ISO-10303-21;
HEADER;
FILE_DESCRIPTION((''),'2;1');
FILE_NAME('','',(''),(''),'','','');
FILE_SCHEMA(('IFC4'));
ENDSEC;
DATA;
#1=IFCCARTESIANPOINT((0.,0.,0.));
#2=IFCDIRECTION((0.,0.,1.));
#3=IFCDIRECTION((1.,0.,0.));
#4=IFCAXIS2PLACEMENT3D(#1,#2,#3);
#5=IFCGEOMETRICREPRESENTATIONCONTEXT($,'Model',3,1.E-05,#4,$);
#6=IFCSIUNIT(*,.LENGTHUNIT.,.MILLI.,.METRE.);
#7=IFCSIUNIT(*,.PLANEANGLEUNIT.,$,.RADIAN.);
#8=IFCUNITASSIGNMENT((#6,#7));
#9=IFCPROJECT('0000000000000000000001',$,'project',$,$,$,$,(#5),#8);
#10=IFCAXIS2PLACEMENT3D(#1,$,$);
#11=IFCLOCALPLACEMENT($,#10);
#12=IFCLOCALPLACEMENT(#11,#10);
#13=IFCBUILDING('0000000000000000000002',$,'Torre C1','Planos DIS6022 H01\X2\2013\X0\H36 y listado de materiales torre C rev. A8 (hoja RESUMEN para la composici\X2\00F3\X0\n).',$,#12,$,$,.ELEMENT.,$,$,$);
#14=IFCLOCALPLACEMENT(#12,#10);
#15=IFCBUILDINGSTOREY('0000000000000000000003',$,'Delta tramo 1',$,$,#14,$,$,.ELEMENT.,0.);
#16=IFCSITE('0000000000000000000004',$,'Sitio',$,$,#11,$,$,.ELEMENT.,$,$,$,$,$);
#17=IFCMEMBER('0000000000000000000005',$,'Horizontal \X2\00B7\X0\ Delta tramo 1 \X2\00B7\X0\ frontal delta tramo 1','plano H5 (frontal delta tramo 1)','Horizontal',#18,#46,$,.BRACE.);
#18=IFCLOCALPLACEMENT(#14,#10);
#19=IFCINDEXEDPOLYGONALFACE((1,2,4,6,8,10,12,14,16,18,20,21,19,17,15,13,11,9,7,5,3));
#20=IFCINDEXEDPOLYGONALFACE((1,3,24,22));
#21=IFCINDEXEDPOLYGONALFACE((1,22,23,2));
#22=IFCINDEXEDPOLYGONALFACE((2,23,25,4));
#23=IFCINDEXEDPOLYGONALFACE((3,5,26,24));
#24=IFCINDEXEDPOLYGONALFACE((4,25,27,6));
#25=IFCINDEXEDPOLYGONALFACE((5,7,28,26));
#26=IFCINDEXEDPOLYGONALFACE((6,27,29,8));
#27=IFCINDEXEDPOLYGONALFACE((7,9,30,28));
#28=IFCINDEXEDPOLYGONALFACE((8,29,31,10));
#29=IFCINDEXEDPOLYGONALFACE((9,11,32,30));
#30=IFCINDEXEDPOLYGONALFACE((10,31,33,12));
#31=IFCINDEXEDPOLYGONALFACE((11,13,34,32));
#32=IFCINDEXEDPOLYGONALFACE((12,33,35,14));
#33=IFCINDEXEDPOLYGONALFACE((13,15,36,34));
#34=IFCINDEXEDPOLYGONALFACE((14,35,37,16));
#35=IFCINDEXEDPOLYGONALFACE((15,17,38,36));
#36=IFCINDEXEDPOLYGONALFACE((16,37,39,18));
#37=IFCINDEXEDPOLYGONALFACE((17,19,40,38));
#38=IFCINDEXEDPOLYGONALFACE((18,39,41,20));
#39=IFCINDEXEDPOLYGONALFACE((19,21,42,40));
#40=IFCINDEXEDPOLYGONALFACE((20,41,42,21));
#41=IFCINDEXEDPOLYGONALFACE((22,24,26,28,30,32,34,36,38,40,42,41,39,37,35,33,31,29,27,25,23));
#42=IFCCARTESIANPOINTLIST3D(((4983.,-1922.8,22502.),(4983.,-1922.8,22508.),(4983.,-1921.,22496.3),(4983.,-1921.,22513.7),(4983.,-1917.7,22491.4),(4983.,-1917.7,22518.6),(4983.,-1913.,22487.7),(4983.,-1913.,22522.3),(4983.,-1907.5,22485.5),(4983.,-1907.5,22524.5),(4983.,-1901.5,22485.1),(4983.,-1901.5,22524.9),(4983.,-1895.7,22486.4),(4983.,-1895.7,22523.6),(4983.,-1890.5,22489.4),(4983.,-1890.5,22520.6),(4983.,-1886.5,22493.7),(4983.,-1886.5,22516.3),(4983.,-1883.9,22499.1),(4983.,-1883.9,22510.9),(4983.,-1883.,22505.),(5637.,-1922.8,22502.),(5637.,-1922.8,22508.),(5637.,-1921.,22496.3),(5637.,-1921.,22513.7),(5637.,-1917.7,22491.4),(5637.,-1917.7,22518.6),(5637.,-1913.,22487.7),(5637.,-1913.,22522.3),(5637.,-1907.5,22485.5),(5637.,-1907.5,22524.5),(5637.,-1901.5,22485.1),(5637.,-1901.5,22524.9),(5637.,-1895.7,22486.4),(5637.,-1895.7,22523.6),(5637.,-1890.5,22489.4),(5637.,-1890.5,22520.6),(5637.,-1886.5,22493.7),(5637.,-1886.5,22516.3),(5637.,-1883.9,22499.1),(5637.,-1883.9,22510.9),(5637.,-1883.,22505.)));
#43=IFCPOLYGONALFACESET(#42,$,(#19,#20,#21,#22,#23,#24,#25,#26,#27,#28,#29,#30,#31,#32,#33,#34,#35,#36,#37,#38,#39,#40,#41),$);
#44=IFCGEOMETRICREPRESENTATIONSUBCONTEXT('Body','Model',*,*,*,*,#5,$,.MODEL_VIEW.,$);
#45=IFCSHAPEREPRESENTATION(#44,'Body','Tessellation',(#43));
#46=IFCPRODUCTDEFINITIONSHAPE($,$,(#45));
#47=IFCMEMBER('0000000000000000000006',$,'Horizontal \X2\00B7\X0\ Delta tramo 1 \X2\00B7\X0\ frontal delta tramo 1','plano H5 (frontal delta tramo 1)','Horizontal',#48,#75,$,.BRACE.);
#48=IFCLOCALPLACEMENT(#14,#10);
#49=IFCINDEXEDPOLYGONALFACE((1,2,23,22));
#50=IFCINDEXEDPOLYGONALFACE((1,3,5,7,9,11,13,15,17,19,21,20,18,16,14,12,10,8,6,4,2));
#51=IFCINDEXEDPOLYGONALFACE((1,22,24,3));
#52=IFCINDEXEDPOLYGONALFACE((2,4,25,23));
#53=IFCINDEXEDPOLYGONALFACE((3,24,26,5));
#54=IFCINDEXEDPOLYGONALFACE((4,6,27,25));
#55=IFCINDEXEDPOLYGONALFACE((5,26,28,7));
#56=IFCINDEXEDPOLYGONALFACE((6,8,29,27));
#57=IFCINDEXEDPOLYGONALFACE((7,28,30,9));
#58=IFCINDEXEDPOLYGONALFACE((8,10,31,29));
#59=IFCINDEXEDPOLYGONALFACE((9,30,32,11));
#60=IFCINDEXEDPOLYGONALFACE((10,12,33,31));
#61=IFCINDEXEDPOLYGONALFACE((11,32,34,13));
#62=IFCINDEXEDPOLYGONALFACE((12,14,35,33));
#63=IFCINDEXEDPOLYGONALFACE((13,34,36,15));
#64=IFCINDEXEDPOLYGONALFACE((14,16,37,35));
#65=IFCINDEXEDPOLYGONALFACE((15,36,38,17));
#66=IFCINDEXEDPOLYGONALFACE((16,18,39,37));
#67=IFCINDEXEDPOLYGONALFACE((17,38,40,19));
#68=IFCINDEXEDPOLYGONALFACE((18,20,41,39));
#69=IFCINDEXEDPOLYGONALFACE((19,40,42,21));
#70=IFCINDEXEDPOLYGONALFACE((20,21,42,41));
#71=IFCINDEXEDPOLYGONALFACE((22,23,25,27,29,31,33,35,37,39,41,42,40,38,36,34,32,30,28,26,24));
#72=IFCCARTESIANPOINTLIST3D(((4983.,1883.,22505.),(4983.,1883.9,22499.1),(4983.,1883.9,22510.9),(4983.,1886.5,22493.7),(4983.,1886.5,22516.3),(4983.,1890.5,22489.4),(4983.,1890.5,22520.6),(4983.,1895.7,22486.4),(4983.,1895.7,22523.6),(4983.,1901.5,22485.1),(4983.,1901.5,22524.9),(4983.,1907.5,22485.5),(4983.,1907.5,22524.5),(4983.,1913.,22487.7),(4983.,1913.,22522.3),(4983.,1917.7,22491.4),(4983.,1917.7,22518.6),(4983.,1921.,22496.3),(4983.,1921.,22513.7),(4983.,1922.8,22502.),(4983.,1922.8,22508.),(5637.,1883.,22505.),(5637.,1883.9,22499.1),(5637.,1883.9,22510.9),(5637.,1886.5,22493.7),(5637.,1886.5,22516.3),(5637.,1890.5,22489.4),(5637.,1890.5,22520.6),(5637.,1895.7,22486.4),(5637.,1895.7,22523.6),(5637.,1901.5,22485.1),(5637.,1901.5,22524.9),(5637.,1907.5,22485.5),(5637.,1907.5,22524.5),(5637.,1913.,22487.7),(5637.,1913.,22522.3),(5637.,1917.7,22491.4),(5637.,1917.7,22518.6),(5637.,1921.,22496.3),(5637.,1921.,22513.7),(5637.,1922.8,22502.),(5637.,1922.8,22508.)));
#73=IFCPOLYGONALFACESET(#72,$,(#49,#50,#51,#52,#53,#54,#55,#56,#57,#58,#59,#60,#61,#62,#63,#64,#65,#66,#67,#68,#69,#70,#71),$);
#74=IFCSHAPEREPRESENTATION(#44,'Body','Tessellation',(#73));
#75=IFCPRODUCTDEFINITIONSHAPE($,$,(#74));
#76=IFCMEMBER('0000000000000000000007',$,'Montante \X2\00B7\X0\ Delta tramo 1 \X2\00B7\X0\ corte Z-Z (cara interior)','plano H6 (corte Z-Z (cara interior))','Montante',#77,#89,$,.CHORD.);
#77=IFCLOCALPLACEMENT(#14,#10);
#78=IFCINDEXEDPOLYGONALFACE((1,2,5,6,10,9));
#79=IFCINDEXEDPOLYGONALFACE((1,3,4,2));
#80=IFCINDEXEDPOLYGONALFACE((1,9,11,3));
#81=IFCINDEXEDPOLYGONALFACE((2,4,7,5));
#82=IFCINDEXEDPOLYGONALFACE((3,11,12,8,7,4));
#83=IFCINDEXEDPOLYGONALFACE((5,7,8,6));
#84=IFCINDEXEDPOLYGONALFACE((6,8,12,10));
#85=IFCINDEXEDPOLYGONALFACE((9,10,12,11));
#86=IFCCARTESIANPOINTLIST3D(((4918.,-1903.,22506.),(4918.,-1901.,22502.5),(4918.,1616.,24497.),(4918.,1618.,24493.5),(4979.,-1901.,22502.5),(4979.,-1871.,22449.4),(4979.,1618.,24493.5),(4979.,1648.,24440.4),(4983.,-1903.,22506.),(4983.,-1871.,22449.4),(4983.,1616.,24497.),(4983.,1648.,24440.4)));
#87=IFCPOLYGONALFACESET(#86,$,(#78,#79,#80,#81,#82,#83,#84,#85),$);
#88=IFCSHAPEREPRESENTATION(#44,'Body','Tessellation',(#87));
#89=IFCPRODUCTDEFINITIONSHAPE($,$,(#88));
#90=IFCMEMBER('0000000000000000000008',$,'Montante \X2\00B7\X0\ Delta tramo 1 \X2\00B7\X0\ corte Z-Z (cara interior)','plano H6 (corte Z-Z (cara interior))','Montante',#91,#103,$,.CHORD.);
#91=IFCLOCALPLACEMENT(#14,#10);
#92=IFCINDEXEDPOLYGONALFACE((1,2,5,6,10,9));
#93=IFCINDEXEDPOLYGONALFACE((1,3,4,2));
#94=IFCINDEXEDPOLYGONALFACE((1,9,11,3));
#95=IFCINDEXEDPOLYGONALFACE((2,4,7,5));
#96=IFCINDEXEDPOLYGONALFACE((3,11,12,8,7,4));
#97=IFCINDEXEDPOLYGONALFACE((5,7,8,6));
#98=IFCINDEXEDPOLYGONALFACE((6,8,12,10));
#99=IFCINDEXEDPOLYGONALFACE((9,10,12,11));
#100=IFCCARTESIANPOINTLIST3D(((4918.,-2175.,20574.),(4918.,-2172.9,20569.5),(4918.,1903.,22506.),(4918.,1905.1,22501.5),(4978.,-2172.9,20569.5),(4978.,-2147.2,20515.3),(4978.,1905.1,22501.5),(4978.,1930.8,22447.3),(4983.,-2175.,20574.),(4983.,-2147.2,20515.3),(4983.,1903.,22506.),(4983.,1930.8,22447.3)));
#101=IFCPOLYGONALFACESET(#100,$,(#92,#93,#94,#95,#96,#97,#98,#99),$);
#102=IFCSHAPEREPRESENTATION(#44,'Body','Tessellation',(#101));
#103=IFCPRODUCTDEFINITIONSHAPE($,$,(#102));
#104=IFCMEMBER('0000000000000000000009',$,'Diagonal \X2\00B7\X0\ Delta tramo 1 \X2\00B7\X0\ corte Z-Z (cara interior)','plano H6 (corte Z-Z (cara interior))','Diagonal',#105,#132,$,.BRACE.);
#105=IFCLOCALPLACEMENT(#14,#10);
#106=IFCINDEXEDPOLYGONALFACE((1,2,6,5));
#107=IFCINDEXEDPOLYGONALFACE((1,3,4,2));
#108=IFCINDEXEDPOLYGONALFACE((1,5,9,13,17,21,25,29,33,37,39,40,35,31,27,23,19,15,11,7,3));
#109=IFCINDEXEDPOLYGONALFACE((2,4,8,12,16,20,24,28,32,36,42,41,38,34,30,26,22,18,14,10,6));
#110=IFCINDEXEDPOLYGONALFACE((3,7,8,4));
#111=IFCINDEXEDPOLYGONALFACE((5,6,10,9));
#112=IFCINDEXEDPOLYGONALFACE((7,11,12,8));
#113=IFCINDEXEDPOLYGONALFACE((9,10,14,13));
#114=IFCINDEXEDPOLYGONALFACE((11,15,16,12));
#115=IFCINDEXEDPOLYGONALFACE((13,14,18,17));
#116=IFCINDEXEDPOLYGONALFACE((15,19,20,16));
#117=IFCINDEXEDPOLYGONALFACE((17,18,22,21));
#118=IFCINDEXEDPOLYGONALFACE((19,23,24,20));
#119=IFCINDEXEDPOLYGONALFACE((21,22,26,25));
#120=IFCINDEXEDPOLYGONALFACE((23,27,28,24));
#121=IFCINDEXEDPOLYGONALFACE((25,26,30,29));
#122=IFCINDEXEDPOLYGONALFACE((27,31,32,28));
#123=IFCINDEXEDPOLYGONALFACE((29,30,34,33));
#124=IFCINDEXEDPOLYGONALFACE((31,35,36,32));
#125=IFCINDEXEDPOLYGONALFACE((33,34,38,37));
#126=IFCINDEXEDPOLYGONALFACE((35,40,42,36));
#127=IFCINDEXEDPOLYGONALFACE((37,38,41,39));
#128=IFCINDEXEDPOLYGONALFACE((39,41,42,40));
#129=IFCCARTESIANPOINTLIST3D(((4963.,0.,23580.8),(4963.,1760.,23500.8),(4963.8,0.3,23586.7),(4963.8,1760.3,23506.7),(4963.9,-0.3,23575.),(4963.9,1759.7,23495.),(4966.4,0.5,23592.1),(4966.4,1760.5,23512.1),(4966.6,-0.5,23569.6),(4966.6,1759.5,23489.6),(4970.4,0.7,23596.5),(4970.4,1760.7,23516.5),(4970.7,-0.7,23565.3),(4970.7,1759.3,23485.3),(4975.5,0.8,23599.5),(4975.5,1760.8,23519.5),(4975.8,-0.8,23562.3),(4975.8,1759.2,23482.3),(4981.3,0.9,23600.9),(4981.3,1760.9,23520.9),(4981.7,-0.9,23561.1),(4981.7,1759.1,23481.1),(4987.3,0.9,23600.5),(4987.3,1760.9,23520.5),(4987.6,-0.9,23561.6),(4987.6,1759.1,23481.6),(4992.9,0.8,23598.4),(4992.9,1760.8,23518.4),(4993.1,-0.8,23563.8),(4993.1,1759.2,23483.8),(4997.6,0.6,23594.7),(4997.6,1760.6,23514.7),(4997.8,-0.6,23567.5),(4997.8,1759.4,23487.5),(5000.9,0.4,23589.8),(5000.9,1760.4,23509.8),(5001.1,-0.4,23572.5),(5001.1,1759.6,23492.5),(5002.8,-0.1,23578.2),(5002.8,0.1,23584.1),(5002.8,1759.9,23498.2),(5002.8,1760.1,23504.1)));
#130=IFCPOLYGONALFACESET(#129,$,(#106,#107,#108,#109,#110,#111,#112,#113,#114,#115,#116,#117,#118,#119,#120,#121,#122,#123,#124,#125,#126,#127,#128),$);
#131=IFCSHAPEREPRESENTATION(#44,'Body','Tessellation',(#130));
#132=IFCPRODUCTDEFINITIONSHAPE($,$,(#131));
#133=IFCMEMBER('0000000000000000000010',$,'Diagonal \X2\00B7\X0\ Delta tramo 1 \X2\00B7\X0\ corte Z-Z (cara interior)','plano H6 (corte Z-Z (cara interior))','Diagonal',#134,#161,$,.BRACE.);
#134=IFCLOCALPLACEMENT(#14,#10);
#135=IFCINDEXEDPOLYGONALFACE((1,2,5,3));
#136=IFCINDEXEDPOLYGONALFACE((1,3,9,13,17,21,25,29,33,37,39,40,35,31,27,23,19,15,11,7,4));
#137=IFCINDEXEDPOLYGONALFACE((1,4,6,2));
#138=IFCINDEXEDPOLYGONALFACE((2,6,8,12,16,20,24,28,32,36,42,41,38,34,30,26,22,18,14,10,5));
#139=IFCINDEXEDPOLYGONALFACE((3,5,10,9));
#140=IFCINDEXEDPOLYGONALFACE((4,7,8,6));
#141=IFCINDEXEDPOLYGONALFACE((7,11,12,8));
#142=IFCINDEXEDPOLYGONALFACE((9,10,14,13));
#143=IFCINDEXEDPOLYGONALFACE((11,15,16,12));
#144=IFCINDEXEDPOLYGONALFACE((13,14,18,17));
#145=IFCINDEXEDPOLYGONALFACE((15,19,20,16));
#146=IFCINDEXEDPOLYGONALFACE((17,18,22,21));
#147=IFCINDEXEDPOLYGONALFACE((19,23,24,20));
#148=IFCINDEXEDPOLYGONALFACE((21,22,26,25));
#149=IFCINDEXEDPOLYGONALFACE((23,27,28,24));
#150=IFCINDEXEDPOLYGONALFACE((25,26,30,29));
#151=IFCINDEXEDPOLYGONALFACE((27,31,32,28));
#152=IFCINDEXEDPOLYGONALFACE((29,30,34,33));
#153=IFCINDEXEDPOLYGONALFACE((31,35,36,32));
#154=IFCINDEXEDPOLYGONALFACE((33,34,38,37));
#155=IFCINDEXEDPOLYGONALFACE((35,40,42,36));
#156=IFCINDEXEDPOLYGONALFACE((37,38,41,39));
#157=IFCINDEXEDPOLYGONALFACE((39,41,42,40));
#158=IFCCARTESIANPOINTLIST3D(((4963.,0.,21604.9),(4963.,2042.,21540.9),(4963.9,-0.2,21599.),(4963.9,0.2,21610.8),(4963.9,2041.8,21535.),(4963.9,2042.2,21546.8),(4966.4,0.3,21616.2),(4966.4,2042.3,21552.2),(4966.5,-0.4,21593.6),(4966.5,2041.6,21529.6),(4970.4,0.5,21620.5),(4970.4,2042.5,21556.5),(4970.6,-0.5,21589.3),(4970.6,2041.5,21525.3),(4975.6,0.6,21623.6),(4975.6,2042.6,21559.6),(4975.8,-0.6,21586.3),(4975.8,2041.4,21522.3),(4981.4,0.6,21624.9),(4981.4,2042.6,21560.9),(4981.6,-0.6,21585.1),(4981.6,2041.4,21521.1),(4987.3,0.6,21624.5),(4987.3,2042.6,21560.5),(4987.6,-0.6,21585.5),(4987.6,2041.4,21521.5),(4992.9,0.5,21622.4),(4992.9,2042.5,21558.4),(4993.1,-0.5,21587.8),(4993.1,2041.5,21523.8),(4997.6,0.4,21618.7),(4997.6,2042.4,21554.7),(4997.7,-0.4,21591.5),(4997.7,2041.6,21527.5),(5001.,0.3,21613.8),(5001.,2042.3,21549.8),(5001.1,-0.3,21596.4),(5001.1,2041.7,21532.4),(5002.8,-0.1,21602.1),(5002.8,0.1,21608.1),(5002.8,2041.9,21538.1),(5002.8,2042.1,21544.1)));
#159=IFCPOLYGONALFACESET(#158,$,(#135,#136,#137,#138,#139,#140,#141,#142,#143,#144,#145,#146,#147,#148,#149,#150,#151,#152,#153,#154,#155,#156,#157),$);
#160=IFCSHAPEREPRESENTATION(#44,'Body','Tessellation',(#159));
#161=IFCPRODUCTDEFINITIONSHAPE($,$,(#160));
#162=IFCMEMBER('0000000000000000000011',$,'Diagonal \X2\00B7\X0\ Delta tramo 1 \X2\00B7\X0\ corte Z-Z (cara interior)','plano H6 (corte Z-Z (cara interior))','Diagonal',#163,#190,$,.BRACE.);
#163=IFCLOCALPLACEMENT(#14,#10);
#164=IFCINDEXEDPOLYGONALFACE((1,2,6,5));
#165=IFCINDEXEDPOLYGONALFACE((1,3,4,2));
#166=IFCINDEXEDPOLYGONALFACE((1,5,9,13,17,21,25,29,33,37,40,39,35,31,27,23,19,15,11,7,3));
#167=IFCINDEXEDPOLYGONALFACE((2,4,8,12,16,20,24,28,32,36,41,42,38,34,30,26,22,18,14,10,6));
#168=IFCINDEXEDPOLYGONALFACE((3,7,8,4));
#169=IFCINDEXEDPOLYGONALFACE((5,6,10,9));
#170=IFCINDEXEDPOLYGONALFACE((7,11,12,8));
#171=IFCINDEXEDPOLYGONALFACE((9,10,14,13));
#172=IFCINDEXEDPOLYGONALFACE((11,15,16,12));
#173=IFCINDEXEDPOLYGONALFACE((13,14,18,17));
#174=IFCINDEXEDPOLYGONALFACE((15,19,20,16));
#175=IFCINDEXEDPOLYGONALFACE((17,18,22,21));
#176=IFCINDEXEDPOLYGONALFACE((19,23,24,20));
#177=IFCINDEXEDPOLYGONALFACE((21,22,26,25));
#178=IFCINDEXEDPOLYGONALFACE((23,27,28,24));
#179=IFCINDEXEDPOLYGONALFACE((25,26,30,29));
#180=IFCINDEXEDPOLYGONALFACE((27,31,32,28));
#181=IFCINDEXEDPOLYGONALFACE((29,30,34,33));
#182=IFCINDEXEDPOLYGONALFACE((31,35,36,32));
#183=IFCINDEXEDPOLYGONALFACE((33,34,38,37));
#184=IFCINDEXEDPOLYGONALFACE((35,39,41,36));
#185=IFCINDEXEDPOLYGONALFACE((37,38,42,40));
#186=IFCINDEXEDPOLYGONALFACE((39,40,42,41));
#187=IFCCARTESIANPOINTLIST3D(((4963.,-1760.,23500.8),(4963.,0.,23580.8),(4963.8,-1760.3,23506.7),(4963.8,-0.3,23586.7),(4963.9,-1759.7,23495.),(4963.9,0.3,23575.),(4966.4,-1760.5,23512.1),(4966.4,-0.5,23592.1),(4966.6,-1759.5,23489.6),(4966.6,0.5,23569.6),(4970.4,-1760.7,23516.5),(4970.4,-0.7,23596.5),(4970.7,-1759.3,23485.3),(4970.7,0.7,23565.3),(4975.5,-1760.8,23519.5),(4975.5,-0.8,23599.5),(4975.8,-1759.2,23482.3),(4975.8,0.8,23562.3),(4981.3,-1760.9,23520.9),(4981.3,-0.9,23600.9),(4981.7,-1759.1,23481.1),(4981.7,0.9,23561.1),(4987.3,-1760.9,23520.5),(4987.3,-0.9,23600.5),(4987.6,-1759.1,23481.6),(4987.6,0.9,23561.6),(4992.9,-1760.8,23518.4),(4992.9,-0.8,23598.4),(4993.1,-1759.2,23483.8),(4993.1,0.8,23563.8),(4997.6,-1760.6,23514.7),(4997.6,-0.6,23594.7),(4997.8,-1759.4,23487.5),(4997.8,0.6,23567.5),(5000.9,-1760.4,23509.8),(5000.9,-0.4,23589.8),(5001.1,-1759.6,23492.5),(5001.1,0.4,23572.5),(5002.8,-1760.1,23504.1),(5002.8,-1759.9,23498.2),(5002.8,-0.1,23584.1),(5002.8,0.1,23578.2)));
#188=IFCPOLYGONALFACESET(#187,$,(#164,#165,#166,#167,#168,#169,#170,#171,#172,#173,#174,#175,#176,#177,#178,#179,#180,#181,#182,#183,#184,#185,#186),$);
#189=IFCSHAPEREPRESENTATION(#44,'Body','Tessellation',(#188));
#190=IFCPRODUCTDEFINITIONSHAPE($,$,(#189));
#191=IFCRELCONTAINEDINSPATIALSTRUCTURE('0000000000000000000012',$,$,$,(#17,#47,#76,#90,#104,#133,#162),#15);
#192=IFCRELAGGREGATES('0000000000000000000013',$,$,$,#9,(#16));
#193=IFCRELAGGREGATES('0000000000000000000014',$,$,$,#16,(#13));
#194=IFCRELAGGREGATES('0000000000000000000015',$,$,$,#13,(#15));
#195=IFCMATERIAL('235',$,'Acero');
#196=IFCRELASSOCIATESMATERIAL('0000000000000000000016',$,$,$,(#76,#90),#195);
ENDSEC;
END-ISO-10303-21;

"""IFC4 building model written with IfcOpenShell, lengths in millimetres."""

from ifc_helpers import new_model, si_unit, frame, frame_2d, origin, origin_with_axes, place, context, subcontext, project, spatial, circle, l_section, extrude, material, element, save


model = new_model("IFC4")

# Units and contexts
model_context = context("Model", 3, precision=1e-05, world=origin_with_axes())
body_context = subcontext(model_context, "Body", "Model", "MODEL_VIEW")
ifc_project = project(units=[si_unit("LENGTHUNIT", "METRE", prefix="MILLI"), si_unit("PLANEANGLEUNIT", "RADIAN")], contexts=[model_context])

# Site, building, storey
site_placement = place(None, origin())
site = spatial("IfcSite", under=ifc_project, at=site_placement, Name="Sitio", CompositionType="ELEMENT")
building_placement = place(site_placement, origin())
building = spatial("IfcBuilding", under=site, at=building_placement, Name="Torre C1", Description="Planos DIS6022 H01–H36 y listado de materiales torre C rev. A8 (hoja RESUMEN para la composición).", CompositionType="ELEMENT")
storey_placement = place(building_placement, origin())
storey = spatial("IfcBuildingStorey", under=building, at=storey_placement, Name="Delta tramo 1", CompositionType="ELEMENT", Elevation=0.0)

# Members
for number, where, z_axis, x_axis, name in (
    (1, (5637.0, -1903.0, 22505.0), (-1.0, 0.0, 0.0), (0.0, 1.0, 0.0), "Horizontal · Delta tramo 1 · frontal delta tramo 1"),
    (2, (5637.0, 1903.0, 22505.0), (-1.0, 0.0, 0.0), (0.0, -1.0, 0.0), "Horizontal · Delta tramo 1 · frontal delta tramo 1"),
):
    element("IfcMember", number, at=place(storey_placement, frame(where, z_axis=z_axis, x_axis=x_axis)), inside=storey, Name=name, Description="plano H5 (frontal delta tramo 1)", ObjectType="Horizontal", PredefinedType="BRACE", context=body_context, shape_type="SweptSolid", body=[
        extrude(circle(Radius=20.0), None, (0.0, 0.0, 1.0), 654.0),
    ])
ifc_material_1 = material(Name="235", Category="Acero")
member_1_placement = place(storey_placement, frame((4983.0, -1903.0, 22506.0), z_axis=(0.0, 0.870351, 0.492432), x_axis=(0.0, 0.492432, -0.870351)))
element("IfcMember", 3, at=member_1_placement, inside=storey, material=ifc_material_1, Name="Montante · Delta tramo 1 · corte Z-Z (cara interior)", Description="plano H6 (corte Z-Z (cara interior))", ObjectType="Montante", PredefinedType="CHORD", context=body_context, shape_type="SweptSolid", body=[
    extrude(l_section(Depth=65.0, Width=65.0, Thickness=4.0, at=frame_2d((32.5, 32.5))), None, (0.0, 0.0, 1.0), 4043.2),
])
member_2_placement = place(storey_placement, frame((4983.0, 1903.0, 22506.0), z_axis=(0.0, -0.903711, -0.428144), x_axis=(-1.0, 0.0, 0.0)))
element("IfcMember", 4, at=member_2_placement, inside=storey, material=ifc_material_1, Name="Montante · Delta tramo 1 · corte Z-Z (cara interior)", Description="plano H6 (corte Z-Z (cara interior))", ObjectType="Montante", PredefinedType="CHORD", context=body_context, shape_type="SweptSolid", body=[
    extrude(l_section(Depth=65.0, Width=65.0, Thickness=5.0, at=frame_2d((32.5, 32.5))), None, (0.0, 0.0, 1.0), 4512.5),
])
member_3_placement = place(storey_placement, frame((4983.0, 1760.0, 23501.0), z_axis=(0.0, -0.998969, 0.045408), x_axis=(-0.999968, -0.000364, -0.00801)))
element("IfcMember", 5, at=member_3_placement, inside=storey, Name="Diagonal · Delta tramo 1 · corte Z-Z (cara interior)", Description="plano H6 (corte Z-Z (cara interior))", ObjectType="Diagonal", PredefinedType="BRACE", context=body_context, shape_type="SweptSolid", body=[
    extrude(circle(Radius=20.0), None, (0.0, 0.0, 1.0), 1761.8),
])
member_4_placement = place(storey_placement, frame((4983.0, 2042.0, 21541.0), z_axis=(0.0, -0.999509, 0.031326), x_axis=(-0.999979, -0.000201, -0.006415)))
element("IfcMember", 6, at=member_4_placement, inside=storey, Name="Diagonal · Delta tramo 1 · corte Z-Z (cara interior)", Description="plano H6 (corte Z-Z (cara interior))", ObjectType="Diagonal", PredefinedType="BRACE", context=body_context, shape_type="SweptSolid", body=[
    extrude(circle(Radius=20.0), None, (0.0, 0.0, 1.0), 2043.0),
])
member_5_placement = place(storey_placement, frame((4983.0, -1760.0, 23501.0), z_axis=(0.0, 0.998969, 0.045408), x_axis=(-0.999968, 0.000364, -0.00801)))
element("IfcMember", 7, at=member_5_placement, inside=storey, Name="Diagonal · Delta tramo 1 · corte Z-Z (cara interior)", Description="plano H6 (corte Z-Z (cara interior))", ObjectType="Diagonal", PredefinedType="BRACE", context=body_context, shape_type="SweptSolid", body=[
    extrude(circle(Radius=20.0), None, (0.0, 0.0, 1.0), 1761.8),
])

save(model, "model.ifc")
